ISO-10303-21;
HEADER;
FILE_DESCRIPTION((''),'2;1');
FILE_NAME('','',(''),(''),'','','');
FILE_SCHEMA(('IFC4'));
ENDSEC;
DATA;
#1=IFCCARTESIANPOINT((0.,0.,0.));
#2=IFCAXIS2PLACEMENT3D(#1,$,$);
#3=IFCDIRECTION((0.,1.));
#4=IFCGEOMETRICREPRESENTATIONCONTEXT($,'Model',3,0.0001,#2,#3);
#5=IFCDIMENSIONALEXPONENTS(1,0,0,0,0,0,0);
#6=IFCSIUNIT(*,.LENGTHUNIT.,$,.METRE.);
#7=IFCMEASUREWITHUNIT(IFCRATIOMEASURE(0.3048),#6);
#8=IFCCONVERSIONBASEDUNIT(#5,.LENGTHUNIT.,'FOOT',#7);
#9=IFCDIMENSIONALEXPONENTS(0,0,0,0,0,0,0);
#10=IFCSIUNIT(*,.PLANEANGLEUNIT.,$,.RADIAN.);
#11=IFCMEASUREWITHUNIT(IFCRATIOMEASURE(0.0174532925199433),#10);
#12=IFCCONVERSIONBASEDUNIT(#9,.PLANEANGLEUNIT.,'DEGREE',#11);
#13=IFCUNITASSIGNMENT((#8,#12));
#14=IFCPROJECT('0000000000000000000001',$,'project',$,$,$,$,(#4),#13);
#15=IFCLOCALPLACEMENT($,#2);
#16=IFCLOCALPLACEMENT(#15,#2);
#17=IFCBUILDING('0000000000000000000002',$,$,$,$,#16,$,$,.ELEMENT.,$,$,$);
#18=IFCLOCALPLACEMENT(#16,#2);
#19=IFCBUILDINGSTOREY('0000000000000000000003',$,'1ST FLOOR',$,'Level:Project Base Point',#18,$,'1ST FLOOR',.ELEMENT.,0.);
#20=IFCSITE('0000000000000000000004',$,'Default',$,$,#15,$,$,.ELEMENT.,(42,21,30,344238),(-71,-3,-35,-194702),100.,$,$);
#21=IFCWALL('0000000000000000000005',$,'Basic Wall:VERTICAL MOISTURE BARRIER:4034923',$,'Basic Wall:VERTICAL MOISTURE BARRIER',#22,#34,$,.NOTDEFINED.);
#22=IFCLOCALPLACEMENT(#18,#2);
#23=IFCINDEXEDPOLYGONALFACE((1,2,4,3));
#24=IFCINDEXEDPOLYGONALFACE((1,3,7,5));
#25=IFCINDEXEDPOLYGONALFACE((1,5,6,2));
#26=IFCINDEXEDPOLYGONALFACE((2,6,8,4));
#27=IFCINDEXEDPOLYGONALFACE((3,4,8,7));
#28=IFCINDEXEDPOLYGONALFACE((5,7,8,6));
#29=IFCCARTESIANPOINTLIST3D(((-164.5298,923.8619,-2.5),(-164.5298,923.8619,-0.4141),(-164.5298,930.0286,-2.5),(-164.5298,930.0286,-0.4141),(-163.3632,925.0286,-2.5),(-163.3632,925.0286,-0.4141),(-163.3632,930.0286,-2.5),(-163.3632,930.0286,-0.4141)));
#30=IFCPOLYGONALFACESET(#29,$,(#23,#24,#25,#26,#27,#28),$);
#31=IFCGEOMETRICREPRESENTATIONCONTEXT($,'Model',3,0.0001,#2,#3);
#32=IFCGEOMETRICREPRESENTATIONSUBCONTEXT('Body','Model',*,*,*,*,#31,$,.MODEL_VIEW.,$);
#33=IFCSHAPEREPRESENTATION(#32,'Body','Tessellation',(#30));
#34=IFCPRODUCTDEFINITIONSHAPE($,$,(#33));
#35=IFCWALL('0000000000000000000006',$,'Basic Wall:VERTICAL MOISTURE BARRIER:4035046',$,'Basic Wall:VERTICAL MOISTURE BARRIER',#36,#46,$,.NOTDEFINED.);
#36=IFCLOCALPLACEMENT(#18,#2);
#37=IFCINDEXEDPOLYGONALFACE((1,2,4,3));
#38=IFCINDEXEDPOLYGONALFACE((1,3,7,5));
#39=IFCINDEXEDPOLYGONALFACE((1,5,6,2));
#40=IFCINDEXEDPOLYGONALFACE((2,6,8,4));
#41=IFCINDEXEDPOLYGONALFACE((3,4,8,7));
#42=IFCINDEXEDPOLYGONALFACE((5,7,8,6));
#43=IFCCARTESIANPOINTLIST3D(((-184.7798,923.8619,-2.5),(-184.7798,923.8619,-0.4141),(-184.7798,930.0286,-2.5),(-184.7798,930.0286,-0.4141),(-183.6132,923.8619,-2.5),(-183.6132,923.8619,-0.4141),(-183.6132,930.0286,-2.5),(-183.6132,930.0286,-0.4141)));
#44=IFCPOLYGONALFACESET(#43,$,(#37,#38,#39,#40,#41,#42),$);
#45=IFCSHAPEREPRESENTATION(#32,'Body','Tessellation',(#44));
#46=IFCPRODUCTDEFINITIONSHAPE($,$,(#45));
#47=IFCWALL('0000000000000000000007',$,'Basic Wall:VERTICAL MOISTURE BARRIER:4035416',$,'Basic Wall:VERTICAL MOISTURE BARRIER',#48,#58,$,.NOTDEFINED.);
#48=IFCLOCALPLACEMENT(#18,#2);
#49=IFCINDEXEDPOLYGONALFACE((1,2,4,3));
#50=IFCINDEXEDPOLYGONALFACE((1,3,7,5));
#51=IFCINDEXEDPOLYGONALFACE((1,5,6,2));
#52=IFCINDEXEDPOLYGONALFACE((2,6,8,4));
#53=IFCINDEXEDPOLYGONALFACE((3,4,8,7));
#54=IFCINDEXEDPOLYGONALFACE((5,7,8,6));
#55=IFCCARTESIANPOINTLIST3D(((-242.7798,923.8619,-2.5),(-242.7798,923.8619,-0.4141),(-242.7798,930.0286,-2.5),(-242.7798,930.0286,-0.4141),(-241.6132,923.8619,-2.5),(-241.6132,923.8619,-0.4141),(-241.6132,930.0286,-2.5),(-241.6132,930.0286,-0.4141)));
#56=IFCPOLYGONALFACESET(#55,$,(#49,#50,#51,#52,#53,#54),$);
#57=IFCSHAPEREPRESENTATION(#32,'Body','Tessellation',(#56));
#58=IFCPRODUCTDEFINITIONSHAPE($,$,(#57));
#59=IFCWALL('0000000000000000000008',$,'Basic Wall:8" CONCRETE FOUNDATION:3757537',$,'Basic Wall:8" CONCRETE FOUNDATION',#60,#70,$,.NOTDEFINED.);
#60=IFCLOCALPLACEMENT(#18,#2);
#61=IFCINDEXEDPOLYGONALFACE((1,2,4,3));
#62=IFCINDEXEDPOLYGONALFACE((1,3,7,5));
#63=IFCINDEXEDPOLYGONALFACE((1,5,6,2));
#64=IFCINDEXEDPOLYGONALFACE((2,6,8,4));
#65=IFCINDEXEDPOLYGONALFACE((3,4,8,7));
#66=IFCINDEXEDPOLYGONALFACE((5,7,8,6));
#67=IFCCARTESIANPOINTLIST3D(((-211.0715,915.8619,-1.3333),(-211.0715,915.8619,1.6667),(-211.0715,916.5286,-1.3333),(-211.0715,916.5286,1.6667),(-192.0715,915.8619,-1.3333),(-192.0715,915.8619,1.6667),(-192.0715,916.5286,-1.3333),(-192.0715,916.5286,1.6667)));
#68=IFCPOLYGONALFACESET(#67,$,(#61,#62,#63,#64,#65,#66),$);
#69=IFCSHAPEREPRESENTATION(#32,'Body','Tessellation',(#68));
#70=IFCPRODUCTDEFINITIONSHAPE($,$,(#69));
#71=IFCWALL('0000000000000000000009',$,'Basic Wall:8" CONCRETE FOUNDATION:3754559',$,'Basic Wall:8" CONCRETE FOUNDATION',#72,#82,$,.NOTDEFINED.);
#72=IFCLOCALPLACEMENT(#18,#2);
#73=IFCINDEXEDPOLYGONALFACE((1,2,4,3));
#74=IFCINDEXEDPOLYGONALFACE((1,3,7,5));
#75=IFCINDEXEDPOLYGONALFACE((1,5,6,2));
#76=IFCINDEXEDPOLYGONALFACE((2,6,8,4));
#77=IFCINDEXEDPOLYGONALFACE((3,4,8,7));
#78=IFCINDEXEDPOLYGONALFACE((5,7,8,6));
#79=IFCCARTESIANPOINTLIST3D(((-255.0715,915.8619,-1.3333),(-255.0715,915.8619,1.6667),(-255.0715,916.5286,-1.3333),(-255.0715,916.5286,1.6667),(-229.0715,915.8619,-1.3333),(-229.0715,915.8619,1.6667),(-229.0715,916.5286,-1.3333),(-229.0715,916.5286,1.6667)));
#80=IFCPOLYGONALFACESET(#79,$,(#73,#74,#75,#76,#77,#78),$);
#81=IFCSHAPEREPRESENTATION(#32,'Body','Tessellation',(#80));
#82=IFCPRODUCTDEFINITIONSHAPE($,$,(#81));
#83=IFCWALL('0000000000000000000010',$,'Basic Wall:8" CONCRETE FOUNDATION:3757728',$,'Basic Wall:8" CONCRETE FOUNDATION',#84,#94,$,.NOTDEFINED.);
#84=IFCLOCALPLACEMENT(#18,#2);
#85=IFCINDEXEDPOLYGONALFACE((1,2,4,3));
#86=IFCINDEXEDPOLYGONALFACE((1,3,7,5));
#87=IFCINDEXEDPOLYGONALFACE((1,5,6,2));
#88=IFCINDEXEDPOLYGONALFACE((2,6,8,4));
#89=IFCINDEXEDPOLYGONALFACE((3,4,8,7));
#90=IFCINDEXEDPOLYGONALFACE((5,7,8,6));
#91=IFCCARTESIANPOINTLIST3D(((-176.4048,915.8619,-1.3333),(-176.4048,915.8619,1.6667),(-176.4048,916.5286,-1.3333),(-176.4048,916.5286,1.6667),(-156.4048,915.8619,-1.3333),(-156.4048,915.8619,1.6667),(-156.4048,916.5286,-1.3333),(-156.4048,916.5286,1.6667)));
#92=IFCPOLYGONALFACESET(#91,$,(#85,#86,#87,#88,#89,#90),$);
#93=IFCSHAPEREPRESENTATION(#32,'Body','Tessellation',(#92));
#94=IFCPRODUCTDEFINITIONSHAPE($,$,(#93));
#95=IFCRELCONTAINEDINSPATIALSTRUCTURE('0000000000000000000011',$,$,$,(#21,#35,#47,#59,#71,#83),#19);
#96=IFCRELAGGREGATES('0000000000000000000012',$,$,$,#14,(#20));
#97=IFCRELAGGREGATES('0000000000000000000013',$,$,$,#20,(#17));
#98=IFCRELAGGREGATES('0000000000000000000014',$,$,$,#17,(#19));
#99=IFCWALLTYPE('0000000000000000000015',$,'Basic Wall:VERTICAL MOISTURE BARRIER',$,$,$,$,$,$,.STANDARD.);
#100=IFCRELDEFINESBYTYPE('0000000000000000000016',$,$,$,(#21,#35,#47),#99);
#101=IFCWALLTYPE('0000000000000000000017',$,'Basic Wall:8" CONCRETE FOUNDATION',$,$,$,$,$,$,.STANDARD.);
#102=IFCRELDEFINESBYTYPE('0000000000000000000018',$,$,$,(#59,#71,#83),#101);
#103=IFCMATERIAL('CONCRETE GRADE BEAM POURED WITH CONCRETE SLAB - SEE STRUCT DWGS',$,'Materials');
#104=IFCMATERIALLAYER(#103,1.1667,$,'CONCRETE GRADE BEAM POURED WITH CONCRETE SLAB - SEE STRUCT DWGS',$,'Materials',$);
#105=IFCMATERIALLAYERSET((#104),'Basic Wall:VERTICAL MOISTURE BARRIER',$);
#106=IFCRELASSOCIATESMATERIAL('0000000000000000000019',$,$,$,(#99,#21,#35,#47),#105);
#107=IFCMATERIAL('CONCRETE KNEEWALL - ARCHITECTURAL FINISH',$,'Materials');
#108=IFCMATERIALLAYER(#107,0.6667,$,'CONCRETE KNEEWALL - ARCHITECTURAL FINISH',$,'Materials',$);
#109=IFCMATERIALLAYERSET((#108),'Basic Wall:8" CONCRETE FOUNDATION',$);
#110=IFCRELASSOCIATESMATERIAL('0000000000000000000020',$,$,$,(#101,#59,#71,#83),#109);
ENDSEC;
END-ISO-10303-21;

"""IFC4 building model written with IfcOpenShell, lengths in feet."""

from ifc_helpers import new_model, entity, si_unit, converted_unit, direction, frame, frame_2d, origin, place, context, subcontext, project, spatial, polyline, rectangle, outline, extrude, clip, bounded_halfspace, material, layer, layer_set, layer_usage, type_object, element, save


model = new_model("IFC4")

# Units and contexts
model_context_1 = context("Model", 3, precision=0.0001, world=origin(), true_north=direction((0.0, 1.0)))
model_context_2 = context("Model", 3, precision=0.0001, world=origin(), true_north=direction((0.0, 1.0)))
body_context = subcontext(model_context_2, "Body", "Model", "MODEL_VIEW")
ifc_project = project(units=[converted_unit("LENGTHUNIT", "FOOT", entity("IfcRatioMeasure", 0.3048), si_unit("LENGTHUNIT", "METRE"), dimensions=[1, 0, 0, 0, 0, 0, 0]), converted_unit("PLANEANGLEUNIT", "DEGREE", entity("IfcRatioMeasure", 0.0174532925199433), si_unit("PLANEANGLEUNIT", "RADIAN"), dimensions=[0, 0, 0, 0, 0, 0, 0])], contexts=[model_context_1])

# Site, building, storey
site_placement = place(None, origin())
site = spatial("IfcSite", under=ifc_project, at=site_placement, Name="Default", CompositionType="ELEMENT", RefLatitude=(42, 21, 30, 344238), RefLongitude=(-71, -3, -35, -194702), RefElevation=100.0)
building_placement = place(site_placement, origin())
building = spatial("IfcBuilding", under=site, at=building_placement, CompositionType="ELEMENT")
storey_placement = place(building_placement, origin())
storey = spatial("IfcBuildingStorey", under=building, at=storey_placement, Name="1ST FLOOR", ObjectType="Level:Project Base Point", LongName="1ST FLOOR", CompositionType="ELEMENT", Elevation=0.0)

# Walls
ifc_material_1 = material(Name="CONCRETE GRADE BEAM POURED WITH CONCRETE SLAB - SEE STRUCT DWGS", Category="Materials")
ifc_layer_1 = layer(ifc_material_1, 1.1667, Name="CONCRETE GRADE BEAM POURED WITH CONCRETE SLAB - SEE STRUCT DWGS", Category="Materials")
ifc_layer_set_1 = layer_set([ifc_layer_1], Name="Basic Wall:VERTICAL MOISTURE BARRIER")
ifc_layer_usage_1 = layer_usage(ifc_layer_set_1, "AXIS2", "NEGATIVE", 0.5833)
wall_type_1 = type_object("IfcWallType", Name="Basic Wall:VERTICAL MOISTURE BARRIER", PredefinedType="STANDARD", material=ifc_layer_set_1)
wall_1_placement = place(storey_placement, frame((-163.9465, 923.8619, -2.5), z_axis=(0.0, 0.0, 1.0), x_axis=(0.0, 1.0, 0.0)))
element("IfcWall", 1, at=wall_1_placement, inside=storey, type_object=wall_type_1, material=ifc_layer_usage_1, Name="Basic Wall:VERTICAL MOISTURE BARRIER:4034923", ObjectType="Basic Wall:VERTICAL MOISTURE BARRIER", PredefinedType="NOTDEFINED", context=body_context, shape_type="Clipping", body=[
    clip(extrude(outline(polyline([(6.1667, -0.5833), (6.1667, 0.5833), (5.0, 0.5833), (0.0, 0.5833), (1.1667, -0.5833), (6.1667, -0.5833)])), origin(), (0.0, 0.0, 1.0), 2.0859), bounded_halfspace(frame((1.1667, -0.5833, 2.0859), z_axis=(0.0, 0.0, -1.0), x_axis=(0.0, -1.0, 0.0)), True, frame((1.1667, -0.5833, 2.0859)), polyline([(0.0, 0.0), (5.0, 0.0), (5.0, 1.1667), (3.8333, 1.1667), (-1.1667, 1.1667), (0.0, 0.0)]))),
])
ifc_layer_usage_2 = layer_usage(ifc_layer_set_1, "AXIS2", "POSITIVE", -0.5833)
wall_2_placement = place(storey_placement, frame((-184.1965, 923.8619, -2.5), z_axis=(0.0, 0.0, 1.0), x_axis=(0.0, 1.0, 0.0)))
element("IfcWall", 2, at=wall_2_placement, inside=storey, type_object=wall_type_1, material=ifc_layer_usage_2, Name="Basic Wall:VERTICAL MOISTURE BARRIER:4035046", ObjectType="Basic Wall:VERTICAL MOISTURE BARRIER", PredefinedType="NOTDEFINED", context=body_context, shape_type="Clipping", body=[
    clip(extrude(rectangle(XDim=6.1667, YDim=1.1667, at=frame_2d((3.0833, 0.0), x_axis=(-1.0, 0.0))), origin(), (0.0, 0.0, 1.0), 2.0859), bounded_halfspace(frame((0.0, -0.5833, 2.0859), z_axis=(0.0, 0.0, -1.0), x_axis=(0.0, -1.0, 0.0)), True, frame((0.0, -0.5833, 2.0859)), polyline([(0.0, 0.0), (5.0, 0.0), (6.1667, 0.0), (6.1667, 1.1667), (1.1667, 1.1667), (0.0, 1.1667), (0.0, 0.0)]))),
])
ifc_layer_usage_3 = layer_usage(ifc_layer_set_1, "AXIS2", "POSITIVE", -0.5833)
wall_3_placement = place(storey_placement, frame((-242.1965, 923.8619, -2.5), z_axis=(0.0, 0.0, 1.0), x_axis=(0.0, 1.0, 0.0)))
element("IfcWall", 3, at=wall_3_placement, inside=storey, type_object=wall_type_1, material=ifc_layer_usage_3, Name="Basic Wall:VERTICAL MOISTURE BARRIER:4035416", ObjectType="Basic Wall:VERTICAL MOISTURE BARRIER", PredefinedType="NOTDEFINED", context=body_context, shape_type="Clipping", body=[
    clip(extrude(rectangle(XDim=6.1667, YDim=1.1667, at=frame_2d((3.0833, 0.0), x_axis=(-1.0, 0.0))), origin(), (0.0, 0.0, 1.0), 2.0859), bounded_halfspace(frame((0.0, -0.5833, 2.0859), z_axis=(0.0, 0.0, -1.0), x_axis=(0.0, -1.0, 0.0)), True, frame((0.0, -0.5833, 2.0859)), polyline([(0.0, 0.0), (5.0, 0.0), (6.1667, 0.0), (6.1667, 1.1667), (1.1667, 1.1667), (0.0, 1.1667), (0.0, 0.0)]))),
])
ifc_material_2 = material(Name="CONCRETE KNEEWALL - ARCHITECTURAL FINISH", Category="Materials")
ifc_layer_2 = layer(ifc_material_2, 0.6667, Name="CONCRETE KNEEWALL - ARCHITECTURAL FINISH", Category="Materials")
ifc_layer_set_2 = layer_set([ifc_layer_2], Name="Basic Wall:8\" CONCRETE FOUNDATION")
ifc_layer_usage_4 = layer_usage(ifc_layer_set_2, "AXIS2", "NEGATIVE", 0.3333)
wall_type_2 = type_object("IfcWallType", Name="Basic Wall:8\" CONCRETE FOUNDATION", PredefinedType="STANDARD", material=ifc_layer_set_2)
wall_4_placement = place(storey_placement, frame((-192.0715, 916.1953, -1.3333), z_axis=(0.0, 0.0, 1.0), x_axis=(-1.0, 0.0, 0.0)))
element("IfcWall", 4, at=wall_4_placement, inside=storey, type_object=wall_type_2, material=ifc_layer_usage_4, Name="Basic Wall:8\" CONCRETE FOUNDATION:3757537", ObjectType="Basic Wall:8\" CONCRETE FOUNDATION", PredefinedType="NOTDEFINED", context=body_context, shape_type="SweptSolid", body=[
    extrude(rectangle(XDim=19.0, YDim=0.6667, at=frame_2d((9.5, 0.0), x_axis=(-1.0, 0.0))), origin(), (0.0, 0.0, 1.0), 3.0),
])
ifc_layer_usage_5 = layer_usage(ifc_layer_set_2, "AXIS2", "NEGATIVE", 0.3333)
wall_5_placement = place(storey_placement, frame((-229.0715, 916.1953, -1.3333), z_axis=(0.0, 0.0, 1.0), x_axis=(-1.0, 0.0, 0.0)))
element("IfcWall", 5, at=wall_5_placement, inside=storey, type_object=wall_type_2, material=ifc_layer_usage_5, Name="Basic Wall:8\" CONCRETE FOUNDATION:3754559", ObjectType="Basic Wall:8\" CONCRETE FOUNDATION", PredefinedType="NOTDEFINED", context=body_context, shape_type="SweptSolid", body=[
    extrude(rectangle(XDim=26.0, YDim=0.6667, at=frame_2d((13.0, 0.0), x_axis=(-1.0, 0.0))), origin(), (0.0, 0.0, 1.0), 3.0),
])
ifc_layer_usage_6 = layer_usage(ifc_layer_set_2, "AXIS2", "NEGATIVE", 0.3333)
wall_6_placement = place(storey_placement, frame((-156.4048, 916.1953, -1.3333), z_axis=(0.0, 0.0, 1.0), x_axis=(-1.0, 0.0, 0.0)))
element("IfcWall", 6, at=wall_6_placement, inside=storey, type_object=wall_type_2, material=ifc_layer_usage_6, Name="Basic Wall:8\" CONCRETE FOUNDATION:3757728", ObjectType="Basic Wall:8\" CONCRETE FOUNDATION", PredefinedType="NOTDEFINED", context=body_context, shape_type="SweptSolid", body=[
    extrude(rectangle(XDim=20.0, YDim=0.6667, at=frame_2d((10.0, 0.0), x_axis=(-1.0, 0.0))), origin(), (0.0, 0.0, 1.0), 3.0),
])

save(model, "model.ifc")
